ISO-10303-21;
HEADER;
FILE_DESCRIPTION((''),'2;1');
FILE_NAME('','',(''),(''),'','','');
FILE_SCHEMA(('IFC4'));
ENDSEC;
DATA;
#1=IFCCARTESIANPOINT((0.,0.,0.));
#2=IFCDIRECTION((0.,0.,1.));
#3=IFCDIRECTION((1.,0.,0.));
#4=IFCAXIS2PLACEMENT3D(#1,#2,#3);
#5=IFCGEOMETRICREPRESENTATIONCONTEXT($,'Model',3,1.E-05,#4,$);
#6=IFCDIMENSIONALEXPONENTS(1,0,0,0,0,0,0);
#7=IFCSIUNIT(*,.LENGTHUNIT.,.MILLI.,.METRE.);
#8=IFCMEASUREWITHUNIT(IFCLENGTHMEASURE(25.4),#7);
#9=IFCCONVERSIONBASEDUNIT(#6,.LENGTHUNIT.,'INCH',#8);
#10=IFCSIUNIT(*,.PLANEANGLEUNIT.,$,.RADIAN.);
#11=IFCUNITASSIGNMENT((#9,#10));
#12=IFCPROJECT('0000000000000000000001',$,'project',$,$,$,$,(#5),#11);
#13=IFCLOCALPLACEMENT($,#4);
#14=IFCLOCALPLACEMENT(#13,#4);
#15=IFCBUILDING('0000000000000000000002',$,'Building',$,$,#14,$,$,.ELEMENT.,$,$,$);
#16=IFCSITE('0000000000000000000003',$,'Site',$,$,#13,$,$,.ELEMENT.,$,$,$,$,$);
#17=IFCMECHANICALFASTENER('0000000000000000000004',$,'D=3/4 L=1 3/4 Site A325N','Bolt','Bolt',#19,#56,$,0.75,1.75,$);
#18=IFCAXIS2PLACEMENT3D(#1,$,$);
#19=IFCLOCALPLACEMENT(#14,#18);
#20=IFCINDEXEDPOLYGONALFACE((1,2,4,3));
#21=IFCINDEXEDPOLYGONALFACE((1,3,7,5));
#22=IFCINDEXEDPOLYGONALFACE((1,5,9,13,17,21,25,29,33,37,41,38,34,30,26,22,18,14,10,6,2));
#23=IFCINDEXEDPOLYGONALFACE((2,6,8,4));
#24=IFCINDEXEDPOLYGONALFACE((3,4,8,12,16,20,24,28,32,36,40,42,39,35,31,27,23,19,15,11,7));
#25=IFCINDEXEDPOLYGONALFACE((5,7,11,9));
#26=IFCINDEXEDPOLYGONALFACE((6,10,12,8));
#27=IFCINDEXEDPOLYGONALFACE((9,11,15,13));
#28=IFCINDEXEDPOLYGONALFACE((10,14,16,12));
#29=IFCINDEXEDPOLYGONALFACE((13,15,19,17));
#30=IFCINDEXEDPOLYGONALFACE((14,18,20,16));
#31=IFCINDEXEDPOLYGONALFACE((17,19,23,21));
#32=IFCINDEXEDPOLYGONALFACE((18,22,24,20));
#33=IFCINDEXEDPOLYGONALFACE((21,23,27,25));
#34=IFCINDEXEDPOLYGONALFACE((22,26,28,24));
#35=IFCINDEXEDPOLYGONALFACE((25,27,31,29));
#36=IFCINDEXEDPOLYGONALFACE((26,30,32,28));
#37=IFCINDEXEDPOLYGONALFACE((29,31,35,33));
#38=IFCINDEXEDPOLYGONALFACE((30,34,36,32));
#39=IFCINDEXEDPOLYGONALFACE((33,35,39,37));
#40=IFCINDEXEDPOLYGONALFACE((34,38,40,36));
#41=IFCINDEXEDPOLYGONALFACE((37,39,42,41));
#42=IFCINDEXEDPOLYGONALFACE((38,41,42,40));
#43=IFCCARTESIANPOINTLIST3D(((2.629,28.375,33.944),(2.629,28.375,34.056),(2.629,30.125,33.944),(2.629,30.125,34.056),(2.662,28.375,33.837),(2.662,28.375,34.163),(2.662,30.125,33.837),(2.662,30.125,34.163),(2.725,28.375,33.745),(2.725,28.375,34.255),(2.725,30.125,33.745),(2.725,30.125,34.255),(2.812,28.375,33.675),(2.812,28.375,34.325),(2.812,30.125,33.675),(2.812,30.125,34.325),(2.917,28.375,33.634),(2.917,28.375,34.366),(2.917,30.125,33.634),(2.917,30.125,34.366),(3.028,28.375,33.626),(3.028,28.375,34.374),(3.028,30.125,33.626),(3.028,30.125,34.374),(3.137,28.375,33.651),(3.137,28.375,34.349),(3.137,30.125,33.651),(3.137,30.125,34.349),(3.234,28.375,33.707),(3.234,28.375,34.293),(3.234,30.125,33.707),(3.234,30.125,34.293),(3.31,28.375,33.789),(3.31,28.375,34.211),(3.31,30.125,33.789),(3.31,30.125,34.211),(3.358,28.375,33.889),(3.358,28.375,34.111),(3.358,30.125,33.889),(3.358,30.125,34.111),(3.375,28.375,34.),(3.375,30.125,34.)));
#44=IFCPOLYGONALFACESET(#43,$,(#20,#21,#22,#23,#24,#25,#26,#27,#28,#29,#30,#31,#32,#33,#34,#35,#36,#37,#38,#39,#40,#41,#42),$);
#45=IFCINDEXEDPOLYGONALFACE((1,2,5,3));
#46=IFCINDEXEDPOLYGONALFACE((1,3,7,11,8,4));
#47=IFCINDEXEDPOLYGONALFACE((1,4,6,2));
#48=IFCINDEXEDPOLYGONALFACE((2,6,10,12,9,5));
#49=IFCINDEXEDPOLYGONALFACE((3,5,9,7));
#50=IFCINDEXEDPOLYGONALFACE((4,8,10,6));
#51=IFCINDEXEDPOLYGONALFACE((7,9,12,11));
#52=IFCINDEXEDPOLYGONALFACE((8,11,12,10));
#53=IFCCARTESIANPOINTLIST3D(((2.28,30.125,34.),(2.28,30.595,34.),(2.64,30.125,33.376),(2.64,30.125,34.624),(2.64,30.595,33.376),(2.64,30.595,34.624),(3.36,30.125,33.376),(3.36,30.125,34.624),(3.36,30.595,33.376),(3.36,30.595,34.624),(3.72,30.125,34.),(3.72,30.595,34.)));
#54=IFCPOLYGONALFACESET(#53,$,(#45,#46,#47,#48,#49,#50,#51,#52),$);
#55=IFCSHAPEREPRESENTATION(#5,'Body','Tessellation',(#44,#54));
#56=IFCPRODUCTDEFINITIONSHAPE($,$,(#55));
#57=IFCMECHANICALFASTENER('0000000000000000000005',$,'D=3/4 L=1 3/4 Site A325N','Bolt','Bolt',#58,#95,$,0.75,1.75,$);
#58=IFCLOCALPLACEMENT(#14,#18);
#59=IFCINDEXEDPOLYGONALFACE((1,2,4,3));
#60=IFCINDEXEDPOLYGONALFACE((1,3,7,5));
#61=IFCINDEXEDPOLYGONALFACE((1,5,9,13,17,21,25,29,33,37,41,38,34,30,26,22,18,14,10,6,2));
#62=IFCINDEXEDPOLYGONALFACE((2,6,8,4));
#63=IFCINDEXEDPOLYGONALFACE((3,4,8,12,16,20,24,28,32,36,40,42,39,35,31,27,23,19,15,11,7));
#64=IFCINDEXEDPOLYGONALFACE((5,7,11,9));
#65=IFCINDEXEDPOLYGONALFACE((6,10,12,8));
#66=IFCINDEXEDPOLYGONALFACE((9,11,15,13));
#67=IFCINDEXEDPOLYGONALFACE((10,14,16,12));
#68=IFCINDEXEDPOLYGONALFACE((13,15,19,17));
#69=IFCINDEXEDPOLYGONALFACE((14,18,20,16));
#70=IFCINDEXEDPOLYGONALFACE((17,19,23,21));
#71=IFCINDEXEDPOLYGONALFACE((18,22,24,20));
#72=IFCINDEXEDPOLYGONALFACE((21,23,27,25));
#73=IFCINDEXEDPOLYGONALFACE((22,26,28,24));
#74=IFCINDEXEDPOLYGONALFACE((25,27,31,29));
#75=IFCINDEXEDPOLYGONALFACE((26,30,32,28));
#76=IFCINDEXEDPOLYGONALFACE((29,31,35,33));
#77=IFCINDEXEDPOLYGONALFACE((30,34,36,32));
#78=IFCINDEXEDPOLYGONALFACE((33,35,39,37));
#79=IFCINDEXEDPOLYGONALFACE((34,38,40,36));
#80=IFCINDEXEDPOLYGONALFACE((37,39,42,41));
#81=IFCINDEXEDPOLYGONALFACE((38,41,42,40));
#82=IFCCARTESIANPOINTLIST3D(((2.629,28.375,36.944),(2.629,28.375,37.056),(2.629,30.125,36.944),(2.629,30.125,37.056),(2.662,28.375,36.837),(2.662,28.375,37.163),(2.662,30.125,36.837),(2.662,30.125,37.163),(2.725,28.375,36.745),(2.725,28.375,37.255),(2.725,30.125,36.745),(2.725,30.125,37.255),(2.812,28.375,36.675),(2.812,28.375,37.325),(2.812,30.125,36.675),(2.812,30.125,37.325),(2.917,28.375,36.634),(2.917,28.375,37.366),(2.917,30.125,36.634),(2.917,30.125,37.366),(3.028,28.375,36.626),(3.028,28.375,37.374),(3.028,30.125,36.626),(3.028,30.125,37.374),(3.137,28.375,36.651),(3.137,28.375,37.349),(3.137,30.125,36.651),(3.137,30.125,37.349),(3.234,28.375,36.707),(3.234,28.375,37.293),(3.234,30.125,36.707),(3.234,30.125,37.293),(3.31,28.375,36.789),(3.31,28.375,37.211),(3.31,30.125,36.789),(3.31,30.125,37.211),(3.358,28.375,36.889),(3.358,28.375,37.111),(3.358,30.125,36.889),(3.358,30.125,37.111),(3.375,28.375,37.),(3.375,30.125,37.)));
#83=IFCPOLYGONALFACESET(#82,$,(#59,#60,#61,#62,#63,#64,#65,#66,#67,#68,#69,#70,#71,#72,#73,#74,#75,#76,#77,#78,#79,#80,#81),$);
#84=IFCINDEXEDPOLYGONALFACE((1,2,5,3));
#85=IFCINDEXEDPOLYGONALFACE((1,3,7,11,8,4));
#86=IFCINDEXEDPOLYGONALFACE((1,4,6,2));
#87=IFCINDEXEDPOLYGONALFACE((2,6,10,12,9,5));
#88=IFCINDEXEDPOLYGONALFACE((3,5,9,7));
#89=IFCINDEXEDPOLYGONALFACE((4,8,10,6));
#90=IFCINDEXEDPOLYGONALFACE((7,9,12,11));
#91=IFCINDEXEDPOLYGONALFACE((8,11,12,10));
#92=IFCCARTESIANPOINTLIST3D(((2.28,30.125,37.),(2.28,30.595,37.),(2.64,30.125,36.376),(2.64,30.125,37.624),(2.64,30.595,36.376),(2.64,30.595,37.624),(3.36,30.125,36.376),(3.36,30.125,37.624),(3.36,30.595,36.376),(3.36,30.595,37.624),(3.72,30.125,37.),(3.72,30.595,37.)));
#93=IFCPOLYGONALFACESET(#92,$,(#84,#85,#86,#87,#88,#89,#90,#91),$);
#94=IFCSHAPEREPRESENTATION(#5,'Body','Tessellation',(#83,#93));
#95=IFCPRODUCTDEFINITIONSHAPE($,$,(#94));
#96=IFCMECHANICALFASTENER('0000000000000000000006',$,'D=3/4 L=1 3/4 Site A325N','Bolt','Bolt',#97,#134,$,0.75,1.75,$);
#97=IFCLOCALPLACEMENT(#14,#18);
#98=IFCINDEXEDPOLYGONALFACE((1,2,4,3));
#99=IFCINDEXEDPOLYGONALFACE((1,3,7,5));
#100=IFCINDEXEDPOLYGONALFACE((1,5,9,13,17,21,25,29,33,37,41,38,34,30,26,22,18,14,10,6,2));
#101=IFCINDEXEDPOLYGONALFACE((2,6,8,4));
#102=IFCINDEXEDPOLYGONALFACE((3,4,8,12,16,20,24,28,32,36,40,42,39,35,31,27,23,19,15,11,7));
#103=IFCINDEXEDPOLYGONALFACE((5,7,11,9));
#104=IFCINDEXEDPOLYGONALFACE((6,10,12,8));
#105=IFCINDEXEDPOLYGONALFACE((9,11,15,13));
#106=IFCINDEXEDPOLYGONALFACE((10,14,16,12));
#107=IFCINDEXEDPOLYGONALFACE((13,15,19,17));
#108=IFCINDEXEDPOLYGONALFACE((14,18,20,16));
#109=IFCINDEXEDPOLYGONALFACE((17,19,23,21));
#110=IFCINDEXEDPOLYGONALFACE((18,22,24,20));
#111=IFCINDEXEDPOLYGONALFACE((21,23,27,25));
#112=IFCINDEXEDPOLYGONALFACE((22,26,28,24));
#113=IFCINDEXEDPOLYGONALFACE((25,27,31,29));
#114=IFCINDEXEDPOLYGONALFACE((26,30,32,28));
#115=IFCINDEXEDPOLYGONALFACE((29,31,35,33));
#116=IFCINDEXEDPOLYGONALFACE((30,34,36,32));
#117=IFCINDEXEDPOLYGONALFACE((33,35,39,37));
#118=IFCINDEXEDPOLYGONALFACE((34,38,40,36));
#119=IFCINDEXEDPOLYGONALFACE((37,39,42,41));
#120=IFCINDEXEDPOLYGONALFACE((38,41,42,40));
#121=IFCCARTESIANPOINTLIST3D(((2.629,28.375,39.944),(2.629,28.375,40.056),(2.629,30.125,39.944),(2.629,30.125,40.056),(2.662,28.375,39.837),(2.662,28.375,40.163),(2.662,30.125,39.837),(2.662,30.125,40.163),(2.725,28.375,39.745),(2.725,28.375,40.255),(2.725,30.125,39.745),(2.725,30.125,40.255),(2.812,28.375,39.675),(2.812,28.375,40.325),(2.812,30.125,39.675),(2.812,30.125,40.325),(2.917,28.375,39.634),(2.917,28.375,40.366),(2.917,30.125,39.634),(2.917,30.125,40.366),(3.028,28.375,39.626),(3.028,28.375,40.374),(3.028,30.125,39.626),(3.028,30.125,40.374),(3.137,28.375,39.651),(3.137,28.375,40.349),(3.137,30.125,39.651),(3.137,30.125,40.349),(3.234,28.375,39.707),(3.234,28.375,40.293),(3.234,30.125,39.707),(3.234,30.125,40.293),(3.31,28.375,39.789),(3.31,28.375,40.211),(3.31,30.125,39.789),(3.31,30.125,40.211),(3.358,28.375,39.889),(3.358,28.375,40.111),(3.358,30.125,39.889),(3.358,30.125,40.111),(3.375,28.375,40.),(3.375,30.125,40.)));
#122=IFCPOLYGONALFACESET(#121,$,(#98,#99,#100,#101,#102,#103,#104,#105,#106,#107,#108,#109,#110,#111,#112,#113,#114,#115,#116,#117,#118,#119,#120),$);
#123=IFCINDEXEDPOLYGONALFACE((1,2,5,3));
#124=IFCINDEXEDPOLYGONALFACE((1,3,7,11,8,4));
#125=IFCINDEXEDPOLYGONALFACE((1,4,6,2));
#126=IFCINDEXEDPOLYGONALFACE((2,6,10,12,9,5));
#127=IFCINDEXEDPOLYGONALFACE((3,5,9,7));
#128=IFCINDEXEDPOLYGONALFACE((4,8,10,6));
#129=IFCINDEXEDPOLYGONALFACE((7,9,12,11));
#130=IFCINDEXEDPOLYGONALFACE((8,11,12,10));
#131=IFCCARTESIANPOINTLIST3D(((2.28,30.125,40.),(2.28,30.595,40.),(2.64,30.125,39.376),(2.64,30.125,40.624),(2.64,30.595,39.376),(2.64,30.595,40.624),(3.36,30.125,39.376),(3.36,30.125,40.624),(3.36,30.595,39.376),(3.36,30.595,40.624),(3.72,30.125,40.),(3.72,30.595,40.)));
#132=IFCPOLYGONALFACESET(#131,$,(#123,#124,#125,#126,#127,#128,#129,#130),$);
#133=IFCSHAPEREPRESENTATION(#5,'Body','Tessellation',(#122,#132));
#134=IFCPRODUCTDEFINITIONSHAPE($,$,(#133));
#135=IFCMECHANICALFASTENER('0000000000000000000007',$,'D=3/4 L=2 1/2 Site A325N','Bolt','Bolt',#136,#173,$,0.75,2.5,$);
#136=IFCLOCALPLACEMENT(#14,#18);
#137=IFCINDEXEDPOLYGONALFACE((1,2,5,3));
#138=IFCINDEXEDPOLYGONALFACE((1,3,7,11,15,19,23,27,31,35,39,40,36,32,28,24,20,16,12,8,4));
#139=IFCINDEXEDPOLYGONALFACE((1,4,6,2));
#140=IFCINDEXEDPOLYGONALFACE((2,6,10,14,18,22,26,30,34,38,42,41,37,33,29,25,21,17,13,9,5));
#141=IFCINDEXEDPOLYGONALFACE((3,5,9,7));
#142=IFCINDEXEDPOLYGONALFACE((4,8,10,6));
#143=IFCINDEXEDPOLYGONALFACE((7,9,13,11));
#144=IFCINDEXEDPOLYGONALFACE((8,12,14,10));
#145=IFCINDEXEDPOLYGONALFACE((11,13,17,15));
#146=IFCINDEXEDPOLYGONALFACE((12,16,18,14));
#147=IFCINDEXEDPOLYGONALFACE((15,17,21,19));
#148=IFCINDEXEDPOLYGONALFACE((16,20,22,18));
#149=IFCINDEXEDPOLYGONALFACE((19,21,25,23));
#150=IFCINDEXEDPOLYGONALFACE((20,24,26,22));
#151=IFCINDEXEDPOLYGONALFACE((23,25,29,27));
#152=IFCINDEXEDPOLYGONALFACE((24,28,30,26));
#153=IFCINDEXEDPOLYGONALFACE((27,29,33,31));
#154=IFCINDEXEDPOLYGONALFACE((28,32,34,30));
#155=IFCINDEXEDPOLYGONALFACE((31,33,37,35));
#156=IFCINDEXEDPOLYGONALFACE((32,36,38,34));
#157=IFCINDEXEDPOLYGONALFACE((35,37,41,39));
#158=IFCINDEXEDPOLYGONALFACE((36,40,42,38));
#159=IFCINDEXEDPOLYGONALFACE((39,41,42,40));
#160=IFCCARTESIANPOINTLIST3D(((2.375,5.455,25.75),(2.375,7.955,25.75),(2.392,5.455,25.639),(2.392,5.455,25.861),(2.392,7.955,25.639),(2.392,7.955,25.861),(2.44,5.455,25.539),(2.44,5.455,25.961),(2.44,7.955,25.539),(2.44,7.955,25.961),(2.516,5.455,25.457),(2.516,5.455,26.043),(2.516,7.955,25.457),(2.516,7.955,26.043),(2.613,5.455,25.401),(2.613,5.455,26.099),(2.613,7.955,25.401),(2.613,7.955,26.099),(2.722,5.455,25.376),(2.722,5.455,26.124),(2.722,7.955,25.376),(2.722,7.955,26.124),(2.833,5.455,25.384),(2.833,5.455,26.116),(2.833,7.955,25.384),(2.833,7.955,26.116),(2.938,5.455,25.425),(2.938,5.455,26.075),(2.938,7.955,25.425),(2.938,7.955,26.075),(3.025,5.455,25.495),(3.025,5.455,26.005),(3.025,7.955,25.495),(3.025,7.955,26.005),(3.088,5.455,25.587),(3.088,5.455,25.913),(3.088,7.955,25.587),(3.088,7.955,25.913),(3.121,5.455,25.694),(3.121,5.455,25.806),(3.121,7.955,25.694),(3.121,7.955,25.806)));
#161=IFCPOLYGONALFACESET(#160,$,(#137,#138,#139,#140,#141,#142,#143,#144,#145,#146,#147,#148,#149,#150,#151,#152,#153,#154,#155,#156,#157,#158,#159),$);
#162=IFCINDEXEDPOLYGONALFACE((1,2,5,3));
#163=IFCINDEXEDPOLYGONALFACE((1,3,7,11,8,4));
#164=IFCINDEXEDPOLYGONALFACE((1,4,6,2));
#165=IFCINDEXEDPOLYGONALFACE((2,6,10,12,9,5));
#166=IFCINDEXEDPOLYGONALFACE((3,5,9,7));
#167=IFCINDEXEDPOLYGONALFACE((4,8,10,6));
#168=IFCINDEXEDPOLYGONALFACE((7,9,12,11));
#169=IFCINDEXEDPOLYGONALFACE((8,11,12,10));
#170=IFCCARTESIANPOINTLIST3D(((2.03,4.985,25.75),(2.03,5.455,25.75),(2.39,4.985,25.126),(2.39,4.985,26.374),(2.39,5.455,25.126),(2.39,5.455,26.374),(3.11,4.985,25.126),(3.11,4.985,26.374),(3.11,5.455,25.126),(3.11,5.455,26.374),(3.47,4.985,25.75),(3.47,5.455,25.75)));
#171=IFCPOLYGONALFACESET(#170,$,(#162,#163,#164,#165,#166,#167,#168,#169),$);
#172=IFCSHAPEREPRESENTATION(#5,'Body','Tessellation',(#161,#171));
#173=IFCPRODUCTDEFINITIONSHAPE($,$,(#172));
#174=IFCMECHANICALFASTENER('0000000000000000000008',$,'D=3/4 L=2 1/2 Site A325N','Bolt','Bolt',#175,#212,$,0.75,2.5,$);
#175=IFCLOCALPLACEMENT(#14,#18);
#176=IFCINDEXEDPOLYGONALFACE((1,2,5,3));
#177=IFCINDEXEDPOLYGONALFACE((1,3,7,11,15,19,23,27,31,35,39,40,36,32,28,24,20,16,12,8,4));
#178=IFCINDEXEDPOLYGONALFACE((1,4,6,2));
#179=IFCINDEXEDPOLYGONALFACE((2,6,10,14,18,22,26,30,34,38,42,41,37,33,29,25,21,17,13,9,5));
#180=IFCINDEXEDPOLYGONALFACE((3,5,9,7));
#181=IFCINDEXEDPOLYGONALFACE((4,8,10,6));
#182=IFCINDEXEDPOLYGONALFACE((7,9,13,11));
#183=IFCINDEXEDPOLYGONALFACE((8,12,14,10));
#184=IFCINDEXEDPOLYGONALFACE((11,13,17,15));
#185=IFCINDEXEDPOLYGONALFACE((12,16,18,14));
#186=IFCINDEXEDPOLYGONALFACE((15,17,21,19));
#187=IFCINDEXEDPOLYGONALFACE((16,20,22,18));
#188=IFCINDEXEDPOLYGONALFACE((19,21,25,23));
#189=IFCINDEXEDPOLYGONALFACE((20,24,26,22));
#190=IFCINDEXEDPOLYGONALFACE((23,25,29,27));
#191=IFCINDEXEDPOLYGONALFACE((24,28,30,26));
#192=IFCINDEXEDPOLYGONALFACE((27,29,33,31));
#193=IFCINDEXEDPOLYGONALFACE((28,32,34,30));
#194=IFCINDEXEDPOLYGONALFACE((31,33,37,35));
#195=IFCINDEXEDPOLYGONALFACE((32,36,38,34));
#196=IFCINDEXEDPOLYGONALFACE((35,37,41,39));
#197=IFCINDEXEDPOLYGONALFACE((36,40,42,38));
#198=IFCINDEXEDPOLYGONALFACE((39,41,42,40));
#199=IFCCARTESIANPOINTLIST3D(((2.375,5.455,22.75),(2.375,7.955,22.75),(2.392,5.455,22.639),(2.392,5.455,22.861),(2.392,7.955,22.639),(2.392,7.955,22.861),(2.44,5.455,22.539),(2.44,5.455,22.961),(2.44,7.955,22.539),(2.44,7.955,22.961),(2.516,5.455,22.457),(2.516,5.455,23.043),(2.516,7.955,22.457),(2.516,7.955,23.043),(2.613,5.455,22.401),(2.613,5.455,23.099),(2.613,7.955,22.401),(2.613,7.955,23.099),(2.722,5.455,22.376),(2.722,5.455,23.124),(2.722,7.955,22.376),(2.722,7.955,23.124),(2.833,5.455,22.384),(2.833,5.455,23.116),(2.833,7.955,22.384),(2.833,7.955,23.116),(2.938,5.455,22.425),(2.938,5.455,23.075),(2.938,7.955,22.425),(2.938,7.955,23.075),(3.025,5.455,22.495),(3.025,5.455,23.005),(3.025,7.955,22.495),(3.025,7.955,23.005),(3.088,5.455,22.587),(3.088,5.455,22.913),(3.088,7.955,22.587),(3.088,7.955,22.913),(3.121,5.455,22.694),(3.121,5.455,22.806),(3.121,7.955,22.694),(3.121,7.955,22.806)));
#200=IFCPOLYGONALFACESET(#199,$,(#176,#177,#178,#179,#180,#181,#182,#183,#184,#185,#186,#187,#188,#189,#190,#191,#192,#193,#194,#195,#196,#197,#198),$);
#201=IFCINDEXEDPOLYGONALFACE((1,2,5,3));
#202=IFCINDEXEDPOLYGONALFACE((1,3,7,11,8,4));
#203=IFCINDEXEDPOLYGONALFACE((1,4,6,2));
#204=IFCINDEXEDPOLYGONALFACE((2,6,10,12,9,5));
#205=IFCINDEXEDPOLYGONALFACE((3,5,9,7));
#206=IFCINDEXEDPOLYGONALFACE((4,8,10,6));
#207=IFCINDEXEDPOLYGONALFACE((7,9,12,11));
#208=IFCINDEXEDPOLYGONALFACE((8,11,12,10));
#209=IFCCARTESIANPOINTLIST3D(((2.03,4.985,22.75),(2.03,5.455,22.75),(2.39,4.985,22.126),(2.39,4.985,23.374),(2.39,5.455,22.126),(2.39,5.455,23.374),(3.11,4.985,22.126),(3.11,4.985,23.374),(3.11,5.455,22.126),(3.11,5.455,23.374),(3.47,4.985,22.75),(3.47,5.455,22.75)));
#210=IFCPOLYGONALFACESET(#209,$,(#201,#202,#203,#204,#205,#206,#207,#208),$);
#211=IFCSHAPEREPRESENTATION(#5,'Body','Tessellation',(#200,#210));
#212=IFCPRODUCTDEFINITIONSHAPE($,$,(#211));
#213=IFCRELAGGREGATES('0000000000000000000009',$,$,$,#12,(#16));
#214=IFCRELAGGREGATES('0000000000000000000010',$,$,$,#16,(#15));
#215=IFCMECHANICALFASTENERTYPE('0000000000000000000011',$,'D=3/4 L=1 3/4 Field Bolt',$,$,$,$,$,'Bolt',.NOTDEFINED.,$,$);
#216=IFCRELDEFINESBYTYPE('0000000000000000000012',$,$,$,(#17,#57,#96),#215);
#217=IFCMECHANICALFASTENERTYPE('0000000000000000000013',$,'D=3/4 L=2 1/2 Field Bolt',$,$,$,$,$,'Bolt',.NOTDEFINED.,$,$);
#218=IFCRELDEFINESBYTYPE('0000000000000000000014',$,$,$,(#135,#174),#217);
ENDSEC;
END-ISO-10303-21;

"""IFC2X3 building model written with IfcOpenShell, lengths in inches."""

from ifc_helpers import new_model, entity, si_unit, converted_unit, frame, origin_with_axes, origin_2d_with_axis, place, context, project, spatial, polyline, circle, outline, extrude, source, transform, mapped, type_object, type_shapes, element, save


model = new_model("IFC2X3")

# Units and contexts
model_context = context("Model", 3, precision=1e-05, world=origin_with_axes())
ifc_project = project(units=[converted_unit("LENGTHUNIT", "INCH", entity("IfcLengthMeasure", 25.4), si_unit("LENGTHUNIT", "METRE", prefix="MILLI"), dimensions=[1, 0, 0, 0, 0, 0, 0]), si_unit("PLANEANGLEUNIT", "RADIAN")], contexts=[model_context])

# Site, building
site_placement = place(None, origin_with_axes())
site = spatial("IfcSite", under=ifc_project, at=site_placement, Name="Site", CompositionType="ELEMENT")
building_placement = place(site_placement, origin_with_axes())
building = spatial("IfcBuilding", under=site, at=building_placement, Name="Building", CompositionType="ELEMENT")

# Mechanical fasteners
mechanical_fastener_type_1 = type_object("IfcMechanicalFastenerType", Name="D=3/4 L=1 3/4 Field Bolt", ElementType="Bolt")
shared_shape_1 = source(origin_with_axes(), model_context, "Body", "SweptSolid", [
    extrude(circle(Radius=0.375, at=origin_2d_with_axis()), frame((0.0, 0.0, 0.0), z_axis=(1.0, 0.0, 0.0), x_axis=(0.0, 1.0, 0.0)), (0.0, 0.0, 1.0), 1.75),
    extrude(outline(polyline([(-0.72, 0.0), (-0.36, 0.624), (0.36, 0.624), (0.72, 0.0), (0.36, -0.624), (-0.36, -0.624), (-0.72, 0.0)])), frame((0.0, 0.0, 0.0), z_axis=(1.0, 0.0, 0.0), x_axis=(0.0, 1.0, 0.0)), (0.0, 0.0, -1.0), 0.47),
])
type_shapes(mechanical_fastener_type_1, [shared_shape_1])
placement_1 = place(building_placement, frame((0.0, 30.0, 46.0), z_axis=(0.0, 0.0, 1.0), x_axis=(1.0, 0.0, 0.0)))
placement_2 = place(placement_1, frame((3.0, 0.125, -3.0), z_axis=(0.0, 0.0, 1.0), x_axis=(0.0, -1.0, 0.0)))
for number, where, z_axis, x_axis, name in (
    (1, (0.0, 0.0, -9.0), (0.0, 0.0, 1.0), (1.0, 0.0, 0.0), "D=3/4 L=1 3/4 Site A325N"),
    (2, (0.0, 0.0, -6.0), (0.0, 0.0, 1.0), (1.0, 0.0, 0.0), "D=3/4 L=1 3/4 Site A325N"),
    (3, (0.0, 0.0, -3.0), (0.0, 0.0, 1.0), (1.0, 0.0, 0.0), "D=3/4 L=1 3/4 Site A325N"),
):
    element("IfcMechanicalFastener", number, at=place(placement_2, frame(where, z_axis=z_axis, x_axis=x_axis)), type_object=mechanical_fastener_type_1, Name=name, Description="Bolt", ObjectType="Bolt", NominalDiameter=0.75, NominalLength=1.75, context=model_context, shape_type="MappedRepresentation", body=[
        mapped(shared_shape_1, transform((0.0, 0.0, 0.0), scale=1.0)),
    ])
mechanical_fastener_type_2 = type_object("IfcMechanicalFastenerType", Name="D=3/4 L=2 1/2 Field Bolt", ElementType="Bolt")
shared_shape_2 = source(origin_with_axes(), model_context, "Body", "SweptSolid", [
    extrude(circle(Radius=0.375, at=origin_2d_with_axis()), frame((0.0, 0.0, 0.0), z_axis=(1.0, 0.0, 0.0), x_axis=(0.0, 1.0, 0.0)), (0.0, 0.0, 1.0), 2.5),
    extrude(outline(polyline([(-0.72, 0.0), (-0.36, 0.624), (0.36, 0.624), (0.72, 0.0), (0.36, -0.624), (-0.36, -0.624), (-0.72, 0.0)])), frame((0.0, 0.0, 0.0), z_axis=(1.0, 0.0, 0.0), x_axis=(0.0, 1.0, 0.0)), (0.0, 0.0, -1.0), 0.47),
])
type_shapes(mechanical_fastener_type_2, [shared_shape_2])
placement_3 = place(building_placement, frame((0.0, 0.0, 21.0), z_axis=(0.0, -1.0, 0.0), x_axis=(0.0, 0.0, 1.0)))
placement_4 = place(placement_3, frame((4.75, -2.75, -5.455), z_axis=(1.0, 0.0, 0.0), x_axis=(0.0, 0.0, -1.0)))
for number, where, z_axis, x_axis, name in (
    (4, (0.0, 0.0, 0.0), (0.0, 0.0, 1.0), (1.0, 0.0, 0.0), "D=3/4 L=2 1/2 Site A325N"),
    (5, (0.0, 0.0, -3.0), (0.0, 0.0, 1.0), (1.0, 0.0, 0.0), "D=3/4 L=2 1/2 Site A325N"),
):
    element("IfcMechanicalFastener", number, at=place(placement_4, frame(where, z_axis=z_axis, x_axis=x_axis)), type_object=mechanical_fastener_type_2, Name=name, Description="Bolt", ObjectType="Bolt", NominalDiameter=0.75, NominalLength=2.5, context=model_context, shape_type="MappedRepresentation", body=[
        mapped(shared_shape_2, transform((0.0, 0.0, 0.0), scale=1.0)),
    ])

save(model, "model.ifc")
